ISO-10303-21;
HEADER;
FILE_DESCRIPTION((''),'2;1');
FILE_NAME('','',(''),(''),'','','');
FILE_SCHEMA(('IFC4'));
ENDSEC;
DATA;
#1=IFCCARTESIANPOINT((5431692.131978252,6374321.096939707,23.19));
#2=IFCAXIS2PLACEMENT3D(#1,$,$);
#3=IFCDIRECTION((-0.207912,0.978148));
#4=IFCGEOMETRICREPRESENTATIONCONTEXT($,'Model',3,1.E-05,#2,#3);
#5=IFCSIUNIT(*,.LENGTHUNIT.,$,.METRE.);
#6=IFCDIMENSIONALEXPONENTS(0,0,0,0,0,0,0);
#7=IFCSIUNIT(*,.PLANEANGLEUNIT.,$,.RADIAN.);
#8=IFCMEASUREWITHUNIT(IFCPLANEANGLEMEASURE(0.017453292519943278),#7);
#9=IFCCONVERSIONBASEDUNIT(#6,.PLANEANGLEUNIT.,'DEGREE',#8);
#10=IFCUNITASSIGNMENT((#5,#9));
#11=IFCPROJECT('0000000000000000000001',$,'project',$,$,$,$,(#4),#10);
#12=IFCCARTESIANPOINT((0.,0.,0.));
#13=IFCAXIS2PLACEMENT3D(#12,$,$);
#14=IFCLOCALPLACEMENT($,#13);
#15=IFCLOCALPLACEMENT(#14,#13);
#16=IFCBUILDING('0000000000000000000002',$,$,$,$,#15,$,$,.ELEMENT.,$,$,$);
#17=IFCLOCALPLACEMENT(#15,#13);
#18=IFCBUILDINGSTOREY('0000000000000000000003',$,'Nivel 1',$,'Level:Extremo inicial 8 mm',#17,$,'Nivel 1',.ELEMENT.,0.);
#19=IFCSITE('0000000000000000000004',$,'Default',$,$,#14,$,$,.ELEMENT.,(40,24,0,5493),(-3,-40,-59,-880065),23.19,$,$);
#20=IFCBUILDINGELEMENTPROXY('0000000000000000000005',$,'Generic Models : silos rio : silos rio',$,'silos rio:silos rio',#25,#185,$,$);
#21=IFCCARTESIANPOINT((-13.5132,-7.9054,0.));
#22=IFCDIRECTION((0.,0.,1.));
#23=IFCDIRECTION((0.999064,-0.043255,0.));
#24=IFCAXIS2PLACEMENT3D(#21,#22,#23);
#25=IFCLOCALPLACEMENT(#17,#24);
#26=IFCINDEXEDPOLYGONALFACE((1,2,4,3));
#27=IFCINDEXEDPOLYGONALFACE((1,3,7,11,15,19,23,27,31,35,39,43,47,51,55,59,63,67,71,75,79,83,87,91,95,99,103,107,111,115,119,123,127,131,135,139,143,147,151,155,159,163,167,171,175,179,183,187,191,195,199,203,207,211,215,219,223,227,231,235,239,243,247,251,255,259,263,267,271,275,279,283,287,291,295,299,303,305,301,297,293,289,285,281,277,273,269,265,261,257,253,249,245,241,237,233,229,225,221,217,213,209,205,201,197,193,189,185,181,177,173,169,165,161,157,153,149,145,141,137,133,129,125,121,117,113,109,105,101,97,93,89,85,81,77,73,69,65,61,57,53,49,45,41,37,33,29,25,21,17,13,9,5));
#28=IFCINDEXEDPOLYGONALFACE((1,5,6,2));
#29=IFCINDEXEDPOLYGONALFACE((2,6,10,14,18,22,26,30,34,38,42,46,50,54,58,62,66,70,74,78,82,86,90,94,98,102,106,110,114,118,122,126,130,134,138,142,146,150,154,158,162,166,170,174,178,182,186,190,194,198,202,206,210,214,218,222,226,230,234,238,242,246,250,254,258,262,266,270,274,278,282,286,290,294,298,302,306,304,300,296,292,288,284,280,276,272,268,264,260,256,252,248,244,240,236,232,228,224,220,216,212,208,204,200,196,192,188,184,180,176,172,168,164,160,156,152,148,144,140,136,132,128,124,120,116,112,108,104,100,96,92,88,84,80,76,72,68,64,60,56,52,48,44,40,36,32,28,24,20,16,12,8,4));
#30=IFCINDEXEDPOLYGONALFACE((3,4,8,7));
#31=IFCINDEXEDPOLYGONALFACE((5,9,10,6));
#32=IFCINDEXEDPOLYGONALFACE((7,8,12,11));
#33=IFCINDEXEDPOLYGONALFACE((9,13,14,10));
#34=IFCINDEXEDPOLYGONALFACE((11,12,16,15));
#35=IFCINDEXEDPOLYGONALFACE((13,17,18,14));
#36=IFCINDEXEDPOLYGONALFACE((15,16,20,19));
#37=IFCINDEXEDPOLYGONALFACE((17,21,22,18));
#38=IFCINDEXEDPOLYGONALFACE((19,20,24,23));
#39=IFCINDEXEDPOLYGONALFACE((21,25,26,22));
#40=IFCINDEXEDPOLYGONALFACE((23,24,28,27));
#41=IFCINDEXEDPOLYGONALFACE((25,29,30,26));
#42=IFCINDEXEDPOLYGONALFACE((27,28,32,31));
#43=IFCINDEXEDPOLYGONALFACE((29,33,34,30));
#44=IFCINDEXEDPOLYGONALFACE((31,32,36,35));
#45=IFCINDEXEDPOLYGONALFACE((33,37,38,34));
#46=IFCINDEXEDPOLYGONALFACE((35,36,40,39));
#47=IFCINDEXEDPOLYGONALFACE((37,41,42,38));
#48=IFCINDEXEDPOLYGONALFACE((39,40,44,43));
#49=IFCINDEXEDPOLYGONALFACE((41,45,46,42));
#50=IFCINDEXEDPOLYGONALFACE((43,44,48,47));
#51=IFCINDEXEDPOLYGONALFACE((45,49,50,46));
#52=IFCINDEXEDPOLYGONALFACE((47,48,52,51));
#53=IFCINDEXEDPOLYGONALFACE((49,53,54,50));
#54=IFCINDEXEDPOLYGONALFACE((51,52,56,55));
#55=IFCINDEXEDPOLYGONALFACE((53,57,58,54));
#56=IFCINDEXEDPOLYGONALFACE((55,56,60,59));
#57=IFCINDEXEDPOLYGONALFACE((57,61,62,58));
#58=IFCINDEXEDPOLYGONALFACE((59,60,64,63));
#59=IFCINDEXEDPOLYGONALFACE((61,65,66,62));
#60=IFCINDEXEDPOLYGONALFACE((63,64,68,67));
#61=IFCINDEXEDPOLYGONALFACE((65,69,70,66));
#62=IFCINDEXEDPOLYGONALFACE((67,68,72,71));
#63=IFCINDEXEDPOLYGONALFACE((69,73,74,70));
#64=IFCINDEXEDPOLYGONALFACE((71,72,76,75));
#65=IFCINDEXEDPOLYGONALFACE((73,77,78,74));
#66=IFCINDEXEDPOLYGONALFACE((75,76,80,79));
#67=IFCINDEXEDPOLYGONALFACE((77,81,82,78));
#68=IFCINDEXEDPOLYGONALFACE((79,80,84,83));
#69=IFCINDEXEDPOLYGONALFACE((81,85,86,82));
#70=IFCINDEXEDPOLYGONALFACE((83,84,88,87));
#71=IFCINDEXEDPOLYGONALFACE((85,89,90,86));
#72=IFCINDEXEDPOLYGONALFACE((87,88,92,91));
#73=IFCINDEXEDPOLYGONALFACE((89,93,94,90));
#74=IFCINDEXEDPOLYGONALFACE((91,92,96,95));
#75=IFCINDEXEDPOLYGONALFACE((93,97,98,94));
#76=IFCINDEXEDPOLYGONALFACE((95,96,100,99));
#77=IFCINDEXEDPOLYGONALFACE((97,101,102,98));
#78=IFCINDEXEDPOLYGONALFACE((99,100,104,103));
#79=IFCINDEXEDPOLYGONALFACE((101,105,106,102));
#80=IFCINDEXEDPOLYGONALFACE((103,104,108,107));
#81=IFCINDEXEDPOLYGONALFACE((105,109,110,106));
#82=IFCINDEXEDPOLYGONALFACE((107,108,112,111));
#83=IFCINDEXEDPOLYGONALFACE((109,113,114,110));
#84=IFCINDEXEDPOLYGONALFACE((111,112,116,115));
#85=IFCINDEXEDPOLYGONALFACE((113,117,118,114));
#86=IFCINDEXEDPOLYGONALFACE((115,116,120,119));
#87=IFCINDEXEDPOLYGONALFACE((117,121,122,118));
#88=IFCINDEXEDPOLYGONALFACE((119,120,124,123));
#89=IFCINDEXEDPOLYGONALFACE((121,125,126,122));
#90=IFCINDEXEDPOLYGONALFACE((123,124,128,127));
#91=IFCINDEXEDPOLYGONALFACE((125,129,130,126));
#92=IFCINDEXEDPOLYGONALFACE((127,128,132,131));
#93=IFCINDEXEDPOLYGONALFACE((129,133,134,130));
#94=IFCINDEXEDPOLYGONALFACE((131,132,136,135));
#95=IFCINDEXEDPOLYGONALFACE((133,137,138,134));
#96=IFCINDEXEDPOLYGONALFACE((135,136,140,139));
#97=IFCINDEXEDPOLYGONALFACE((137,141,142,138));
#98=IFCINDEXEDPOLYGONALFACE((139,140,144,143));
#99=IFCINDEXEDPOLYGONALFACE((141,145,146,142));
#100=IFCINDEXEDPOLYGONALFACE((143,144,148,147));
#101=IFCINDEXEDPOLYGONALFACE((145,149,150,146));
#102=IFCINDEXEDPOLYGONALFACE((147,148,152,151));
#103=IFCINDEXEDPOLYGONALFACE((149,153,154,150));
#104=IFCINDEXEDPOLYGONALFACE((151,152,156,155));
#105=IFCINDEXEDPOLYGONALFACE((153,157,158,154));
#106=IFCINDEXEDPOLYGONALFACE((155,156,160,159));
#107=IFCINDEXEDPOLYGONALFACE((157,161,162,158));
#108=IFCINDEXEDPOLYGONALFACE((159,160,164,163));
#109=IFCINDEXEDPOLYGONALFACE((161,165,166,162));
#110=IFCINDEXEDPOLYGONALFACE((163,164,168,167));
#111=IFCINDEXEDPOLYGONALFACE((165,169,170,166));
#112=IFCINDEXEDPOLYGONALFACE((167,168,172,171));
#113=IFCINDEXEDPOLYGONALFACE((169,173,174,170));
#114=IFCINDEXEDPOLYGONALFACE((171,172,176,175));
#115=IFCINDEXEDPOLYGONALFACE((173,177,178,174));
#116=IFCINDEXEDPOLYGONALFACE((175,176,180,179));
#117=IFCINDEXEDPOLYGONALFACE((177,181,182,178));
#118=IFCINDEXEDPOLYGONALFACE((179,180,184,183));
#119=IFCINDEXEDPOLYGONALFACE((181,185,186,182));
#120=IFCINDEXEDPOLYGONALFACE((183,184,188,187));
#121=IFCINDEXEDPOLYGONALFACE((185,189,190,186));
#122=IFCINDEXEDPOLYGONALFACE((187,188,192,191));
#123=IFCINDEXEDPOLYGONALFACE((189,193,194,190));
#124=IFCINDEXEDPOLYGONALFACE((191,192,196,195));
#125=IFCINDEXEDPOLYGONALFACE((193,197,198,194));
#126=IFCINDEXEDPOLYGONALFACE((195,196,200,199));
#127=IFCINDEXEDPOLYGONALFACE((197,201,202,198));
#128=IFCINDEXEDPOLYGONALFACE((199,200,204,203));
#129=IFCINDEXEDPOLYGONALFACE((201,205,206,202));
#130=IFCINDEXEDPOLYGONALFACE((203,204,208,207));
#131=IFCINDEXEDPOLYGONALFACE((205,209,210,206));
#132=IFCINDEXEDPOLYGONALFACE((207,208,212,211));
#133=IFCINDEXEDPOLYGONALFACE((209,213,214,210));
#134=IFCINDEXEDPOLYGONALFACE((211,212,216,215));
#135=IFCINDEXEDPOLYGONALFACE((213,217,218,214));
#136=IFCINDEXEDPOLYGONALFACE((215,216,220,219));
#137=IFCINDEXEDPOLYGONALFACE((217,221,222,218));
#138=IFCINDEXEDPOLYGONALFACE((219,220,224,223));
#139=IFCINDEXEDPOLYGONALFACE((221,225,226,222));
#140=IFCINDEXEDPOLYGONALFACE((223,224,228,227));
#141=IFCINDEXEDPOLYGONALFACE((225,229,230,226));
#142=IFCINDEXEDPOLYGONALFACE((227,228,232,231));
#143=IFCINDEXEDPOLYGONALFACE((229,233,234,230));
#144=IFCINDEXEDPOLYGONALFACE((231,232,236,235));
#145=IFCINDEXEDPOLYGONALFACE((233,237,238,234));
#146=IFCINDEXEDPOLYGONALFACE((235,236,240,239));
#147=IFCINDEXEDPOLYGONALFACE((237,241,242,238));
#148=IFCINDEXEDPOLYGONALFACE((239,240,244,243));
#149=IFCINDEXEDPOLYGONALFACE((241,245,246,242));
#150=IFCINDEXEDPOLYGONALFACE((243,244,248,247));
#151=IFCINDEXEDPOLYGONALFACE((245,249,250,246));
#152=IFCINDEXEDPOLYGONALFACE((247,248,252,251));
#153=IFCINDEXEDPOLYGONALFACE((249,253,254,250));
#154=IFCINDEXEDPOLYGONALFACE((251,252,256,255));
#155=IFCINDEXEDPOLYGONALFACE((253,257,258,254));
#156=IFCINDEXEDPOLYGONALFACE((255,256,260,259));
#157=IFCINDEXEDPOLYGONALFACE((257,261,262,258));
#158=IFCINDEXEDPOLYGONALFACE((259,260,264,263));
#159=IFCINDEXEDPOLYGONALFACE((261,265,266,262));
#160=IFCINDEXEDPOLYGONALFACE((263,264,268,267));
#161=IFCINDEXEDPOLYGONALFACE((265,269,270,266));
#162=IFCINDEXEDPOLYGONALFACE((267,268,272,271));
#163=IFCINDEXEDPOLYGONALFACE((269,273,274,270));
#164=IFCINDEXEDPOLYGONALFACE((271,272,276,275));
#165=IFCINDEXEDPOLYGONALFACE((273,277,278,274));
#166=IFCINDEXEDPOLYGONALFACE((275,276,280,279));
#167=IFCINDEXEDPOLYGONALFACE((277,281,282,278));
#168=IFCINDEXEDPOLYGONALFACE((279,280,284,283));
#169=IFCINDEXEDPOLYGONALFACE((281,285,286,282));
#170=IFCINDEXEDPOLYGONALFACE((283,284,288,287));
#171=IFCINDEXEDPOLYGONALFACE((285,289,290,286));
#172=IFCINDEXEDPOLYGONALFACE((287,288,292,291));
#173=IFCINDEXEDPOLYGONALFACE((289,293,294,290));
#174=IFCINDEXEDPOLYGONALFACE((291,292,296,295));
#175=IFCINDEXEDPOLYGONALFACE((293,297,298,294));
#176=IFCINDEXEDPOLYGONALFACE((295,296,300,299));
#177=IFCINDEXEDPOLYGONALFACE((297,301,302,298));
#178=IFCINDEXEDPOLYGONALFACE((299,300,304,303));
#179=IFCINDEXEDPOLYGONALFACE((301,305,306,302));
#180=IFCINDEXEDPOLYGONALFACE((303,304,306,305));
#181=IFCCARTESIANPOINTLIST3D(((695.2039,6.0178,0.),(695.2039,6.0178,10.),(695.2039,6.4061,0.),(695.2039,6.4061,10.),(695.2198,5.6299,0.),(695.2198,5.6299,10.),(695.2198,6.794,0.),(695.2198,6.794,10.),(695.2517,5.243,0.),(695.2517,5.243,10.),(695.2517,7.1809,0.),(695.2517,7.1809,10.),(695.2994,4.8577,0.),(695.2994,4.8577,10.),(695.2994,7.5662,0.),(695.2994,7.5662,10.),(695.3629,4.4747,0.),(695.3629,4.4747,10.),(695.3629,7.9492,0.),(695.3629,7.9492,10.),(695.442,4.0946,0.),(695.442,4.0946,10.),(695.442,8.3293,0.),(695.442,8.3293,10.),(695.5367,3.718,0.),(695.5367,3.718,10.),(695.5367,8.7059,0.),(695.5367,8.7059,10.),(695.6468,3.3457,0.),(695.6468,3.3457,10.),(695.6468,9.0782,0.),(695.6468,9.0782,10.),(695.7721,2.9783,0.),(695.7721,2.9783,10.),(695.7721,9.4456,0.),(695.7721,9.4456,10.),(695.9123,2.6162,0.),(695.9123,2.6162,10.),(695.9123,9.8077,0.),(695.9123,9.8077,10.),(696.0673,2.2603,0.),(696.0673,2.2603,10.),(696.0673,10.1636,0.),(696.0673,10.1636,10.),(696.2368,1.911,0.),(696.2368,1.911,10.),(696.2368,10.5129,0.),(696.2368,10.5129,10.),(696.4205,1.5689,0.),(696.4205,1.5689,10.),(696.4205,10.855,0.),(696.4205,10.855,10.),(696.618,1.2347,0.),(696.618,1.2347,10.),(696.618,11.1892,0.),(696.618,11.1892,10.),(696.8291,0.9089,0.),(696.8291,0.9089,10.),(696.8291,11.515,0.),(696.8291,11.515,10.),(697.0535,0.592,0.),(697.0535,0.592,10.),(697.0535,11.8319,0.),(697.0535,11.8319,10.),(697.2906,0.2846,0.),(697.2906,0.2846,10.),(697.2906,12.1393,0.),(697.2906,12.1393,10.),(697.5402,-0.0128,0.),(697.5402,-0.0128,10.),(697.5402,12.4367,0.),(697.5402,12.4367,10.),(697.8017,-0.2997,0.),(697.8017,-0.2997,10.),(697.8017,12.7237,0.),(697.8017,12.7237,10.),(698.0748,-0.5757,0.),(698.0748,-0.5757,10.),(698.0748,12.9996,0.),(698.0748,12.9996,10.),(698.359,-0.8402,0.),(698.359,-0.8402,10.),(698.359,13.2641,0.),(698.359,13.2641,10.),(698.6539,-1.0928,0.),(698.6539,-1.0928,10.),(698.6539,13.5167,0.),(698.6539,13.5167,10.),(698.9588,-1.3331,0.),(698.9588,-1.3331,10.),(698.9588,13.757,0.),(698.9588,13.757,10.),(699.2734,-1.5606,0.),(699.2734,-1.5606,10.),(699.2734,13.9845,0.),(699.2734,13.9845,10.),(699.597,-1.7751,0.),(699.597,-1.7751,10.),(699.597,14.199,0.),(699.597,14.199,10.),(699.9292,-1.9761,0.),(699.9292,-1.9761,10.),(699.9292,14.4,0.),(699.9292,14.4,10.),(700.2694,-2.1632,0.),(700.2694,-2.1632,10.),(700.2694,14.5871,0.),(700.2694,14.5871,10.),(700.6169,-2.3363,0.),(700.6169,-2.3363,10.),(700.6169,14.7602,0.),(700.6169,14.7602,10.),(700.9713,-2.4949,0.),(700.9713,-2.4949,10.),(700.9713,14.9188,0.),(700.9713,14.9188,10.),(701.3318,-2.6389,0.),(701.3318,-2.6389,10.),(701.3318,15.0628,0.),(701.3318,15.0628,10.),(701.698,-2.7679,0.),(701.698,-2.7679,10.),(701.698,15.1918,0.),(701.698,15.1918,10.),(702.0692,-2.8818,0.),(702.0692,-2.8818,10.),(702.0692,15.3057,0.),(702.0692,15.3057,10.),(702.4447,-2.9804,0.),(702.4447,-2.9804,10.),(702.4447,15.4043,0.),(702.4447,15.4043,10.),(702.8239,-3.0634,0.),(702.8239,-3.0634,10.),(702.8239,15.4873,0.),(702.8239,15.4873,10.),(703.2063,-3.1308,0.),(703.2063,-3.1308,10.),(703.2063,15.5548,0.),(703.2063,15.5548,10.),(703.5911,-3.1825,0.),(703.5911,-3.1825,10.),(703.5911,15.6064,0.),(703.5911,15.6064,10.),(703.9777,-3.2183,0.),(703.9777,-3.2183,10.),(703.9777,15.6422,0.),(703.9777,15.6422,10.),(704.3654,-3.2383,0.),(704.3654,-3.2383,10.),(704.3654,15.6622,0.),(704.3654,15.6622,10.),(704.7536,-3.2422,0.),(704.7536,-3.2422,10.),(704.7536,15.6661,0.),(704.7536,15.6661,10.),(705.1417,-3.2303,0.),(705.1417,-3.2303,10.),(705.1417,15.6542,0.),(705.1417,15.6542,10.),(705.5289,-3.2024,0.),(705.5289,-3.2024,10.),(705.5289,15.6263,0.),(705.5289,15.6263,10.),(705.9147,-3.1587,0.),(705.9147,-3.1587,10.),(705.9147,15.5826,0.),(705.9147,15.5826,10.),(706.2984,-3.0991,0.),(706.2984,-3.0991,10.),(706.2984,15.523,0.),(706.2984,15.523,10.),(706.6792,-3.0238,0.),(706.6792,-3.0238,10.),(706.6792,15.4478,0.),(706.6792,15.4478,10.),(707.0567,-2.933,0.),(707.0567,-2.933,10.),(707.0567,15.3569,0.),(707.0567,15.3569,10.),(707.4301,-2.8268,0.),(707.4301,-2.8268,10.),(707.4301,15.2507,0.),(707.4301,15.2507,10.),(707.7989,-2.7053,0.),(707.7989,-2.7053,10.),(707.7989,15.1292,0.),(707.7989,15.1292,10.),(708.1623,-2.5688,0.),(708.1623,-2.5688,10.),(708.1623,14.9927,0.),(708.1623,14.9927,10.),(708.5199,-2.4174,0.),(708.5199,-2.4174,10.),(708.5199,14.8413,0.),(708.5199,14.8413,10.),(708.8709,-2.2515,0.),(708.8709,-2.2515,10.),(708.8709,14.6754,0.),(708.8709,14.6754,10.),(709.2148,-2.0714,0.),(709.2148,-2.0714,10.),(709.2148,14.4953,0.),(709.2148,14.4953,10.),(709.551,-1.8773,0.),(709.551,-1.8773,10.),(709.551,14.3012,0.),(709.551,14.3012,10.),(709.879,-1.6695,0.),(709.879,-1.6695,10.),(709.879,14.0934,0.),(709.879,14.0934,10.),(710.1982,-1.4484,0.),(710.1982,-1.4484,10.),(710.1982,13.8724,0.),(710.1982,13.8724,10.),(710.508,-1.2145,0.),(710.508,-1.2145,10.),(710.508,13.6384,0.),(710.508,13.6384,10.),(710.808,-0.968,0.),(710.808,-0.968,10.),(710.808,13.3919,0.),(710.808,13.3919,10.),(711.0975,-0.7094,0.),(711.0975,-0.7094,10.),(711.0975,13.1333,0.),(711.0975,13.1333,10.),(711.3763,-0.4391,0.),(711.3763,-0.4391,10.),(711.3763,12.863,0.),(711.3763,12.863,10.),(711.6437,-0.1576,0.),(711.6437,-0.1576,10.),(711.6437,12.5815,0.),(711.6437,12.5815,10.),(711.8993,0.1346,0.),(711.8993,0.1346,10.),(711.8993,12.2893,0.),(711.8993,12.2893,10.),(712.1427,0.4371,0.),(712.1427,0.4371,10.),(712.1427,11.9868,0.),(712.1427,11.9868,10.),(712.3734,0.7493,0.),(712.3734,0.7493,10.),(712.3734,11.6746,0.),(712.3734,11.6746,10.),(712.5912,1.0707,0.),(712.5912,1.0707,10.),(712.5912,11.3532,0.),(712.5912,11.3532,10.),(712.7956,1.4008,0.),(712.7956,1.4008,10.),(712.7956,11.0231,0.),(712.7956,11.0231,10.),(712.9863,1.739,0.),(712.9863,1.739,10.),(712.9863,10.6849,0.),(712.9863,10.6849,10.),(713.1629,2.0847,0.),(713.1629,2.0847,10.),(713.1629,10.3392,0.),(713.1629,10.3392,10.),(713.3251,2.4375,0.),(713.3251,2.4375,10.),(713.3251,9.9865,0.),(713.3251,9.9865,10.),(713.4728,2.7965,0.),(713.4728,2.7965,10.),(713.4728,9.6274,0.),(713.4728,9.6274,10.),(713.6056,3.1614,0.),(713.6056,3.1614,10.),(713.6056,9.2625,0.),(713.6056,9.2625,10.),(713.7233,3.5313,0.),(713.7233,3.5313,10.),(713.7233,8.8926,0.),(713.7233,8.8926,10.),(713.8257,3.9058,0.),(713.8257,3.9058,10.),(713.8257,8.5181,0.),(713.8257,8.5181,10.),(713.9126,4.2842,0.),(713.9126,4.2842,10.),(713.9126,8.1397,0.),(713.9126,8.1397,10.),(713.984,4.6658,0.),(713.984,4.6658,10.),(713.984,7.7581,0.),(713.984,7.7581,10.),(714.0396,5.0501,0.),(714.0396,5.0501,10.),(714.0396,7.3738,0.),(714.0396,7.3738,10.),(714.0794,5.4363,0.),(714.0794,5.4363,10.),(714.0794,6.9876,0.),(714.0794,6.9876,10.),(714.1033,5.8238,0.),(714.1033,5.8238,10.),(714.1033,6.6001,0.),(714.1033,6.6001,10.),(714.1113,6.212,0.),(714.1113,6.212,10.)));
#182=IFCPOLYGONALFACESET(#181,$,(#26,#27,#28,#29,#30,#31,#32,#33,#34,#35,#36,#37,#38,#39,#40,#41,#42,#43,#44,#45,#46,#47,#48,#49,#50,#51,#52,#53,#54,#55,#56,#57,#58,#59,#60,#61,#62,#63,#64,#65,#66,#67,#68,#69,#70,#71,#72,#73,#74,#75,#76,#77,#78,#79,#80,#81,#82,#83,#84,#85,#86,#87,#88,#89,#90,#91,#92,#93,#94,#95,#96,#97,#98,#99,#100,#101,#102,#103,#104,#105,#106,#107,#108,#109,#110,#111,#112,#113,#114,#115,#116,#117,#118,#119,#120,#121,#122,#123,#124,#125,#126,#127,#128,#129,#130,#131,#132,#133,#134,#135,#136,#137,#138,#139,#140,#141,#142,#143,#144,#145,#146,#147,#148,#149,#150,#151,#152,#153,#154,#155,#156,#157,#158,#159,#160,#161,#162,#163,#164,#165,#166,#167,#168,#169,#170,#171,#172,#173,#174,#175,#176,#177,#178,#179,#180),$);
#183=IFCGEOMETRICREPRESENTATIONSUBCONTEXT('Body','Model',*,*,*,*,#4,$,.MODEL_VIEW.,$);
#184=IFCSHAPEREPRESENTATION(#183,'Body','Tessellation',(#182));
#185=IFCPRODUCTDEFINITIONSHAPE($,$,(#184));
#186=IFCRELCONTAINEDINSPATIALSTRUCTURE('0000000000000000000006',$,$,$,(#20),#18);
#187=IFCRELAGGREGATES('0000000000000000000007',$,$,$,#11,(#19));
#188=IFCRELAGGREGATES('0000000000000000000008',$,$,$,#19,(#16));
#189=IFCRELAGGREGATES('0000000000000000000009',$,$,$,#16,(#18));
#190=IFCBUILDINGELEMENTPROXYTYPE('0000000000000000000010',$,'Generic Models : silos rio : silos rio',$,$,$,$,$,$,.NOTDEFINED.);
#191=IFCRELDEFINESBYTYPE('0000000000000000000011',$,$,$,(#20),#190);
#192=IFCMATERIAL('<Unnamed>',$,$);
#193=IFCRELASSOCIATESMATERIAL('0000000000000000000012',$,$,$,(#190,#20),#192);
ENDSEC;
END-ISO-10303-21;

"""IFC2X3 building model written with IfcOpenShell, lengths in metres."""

from ifc_helpers import new_model, entity, si_unit, converted_unit, direction, frame, frame_2d, origin, place, context, subcontext, project, spatial, circle, extrude, source, transform, mapped, material, type_object, type_shapes, element, save


model = new_model("IFC2X3")

# Units and contexts
model_context = context("Model", 3, precision=1e-05, world=frame((5431692.131978252, 6374321.096939707, 23.19)), true_north=direction((-0.207912, 0.978148)))
body_context = subcontext(model_context, "Body", "Model", "MODEL_VIEW")
ifc_project = project(units=[si_unit("LENGTHUNIT", "METRE"), converted_unit("PLANEANGLEUNIT", "DEGREE", entity("IfcPlaneAngleMeasure", 0.017453292519943278), si_unit("PLANEANGLEUNIT", "RADIAN"), dimensions=[0, 0, 0, 0, 0, 0, 0])], contexts=[model_context])

# Site, building, storey
site_placement = place(None, origin())
site = spatial("IfcSite", under=ifc_project, at=site_placement, Name="Default", CompositionType="ELEMENT", RefLatitude=(40, 24, 0, 5493), RefLongitude=(-3, -40, -59, -880065), RefElevation=23.19)
building_placement = place(site_placement, origin())
building = spatial("IfcBuilding", under=site, at=building_placement, CompositionType="ELEMENT")
storey_placement = place(building_placement, origin())
storey = spatial("IfcBuildingStorey", under=building, at=storey_placement, Name="Nivel 1", ObjectType="Level:Extremo inicial 8 mm", LongName="Nivel 1", CompositionType="ELEMENT", Elevation=0.0)

# Building element proxy
ifc_material_1 = material(Name="<Unnamed>")
building_element_proxy_type_1 = type_object("IfcBuildingElementProxyType", Name="Generic Models : silos rio : silos rio", PredefinedType="NOTDEFINED", material=ifc_material_1)
shared_shape_1 = source(origin(), body_context, "Body", "SweptSolid", [
    extrude(circle(Radius=9.4547, at=frame_2d((0.0, 0.0), x_axis=(1.0, 0.0))), frame((704.6566, 6.212, 0.0)), (0.0, 0.0, 1.0), 10.0),
])
type_shapes(building_element_proxy_type_1, [shared_shape_1])
proxy_1_placement = place(storey_placement, frame((-13.5132, -7.9054, 0.0), z_axis=(0.0, 0.0, 1.0), x_axis=(0.999064, -0.043255, 0.0)))
element("IfcBuildingElementProxy", 1, at=proxy_1_placement, inside=storey, type_object=building_element_proxy_type_1, material=ifc_material_1, Name="Generic Models : silos rio : silos rio", ObjectType="silos rio:silos rio", context=body_context, shape_type="MappedRepresentation", body=[
    mapped(shared_shape_1, transform((0.0, 0.0, 0.0), scale=1.0)),
])

save(model, "model.ifc")
